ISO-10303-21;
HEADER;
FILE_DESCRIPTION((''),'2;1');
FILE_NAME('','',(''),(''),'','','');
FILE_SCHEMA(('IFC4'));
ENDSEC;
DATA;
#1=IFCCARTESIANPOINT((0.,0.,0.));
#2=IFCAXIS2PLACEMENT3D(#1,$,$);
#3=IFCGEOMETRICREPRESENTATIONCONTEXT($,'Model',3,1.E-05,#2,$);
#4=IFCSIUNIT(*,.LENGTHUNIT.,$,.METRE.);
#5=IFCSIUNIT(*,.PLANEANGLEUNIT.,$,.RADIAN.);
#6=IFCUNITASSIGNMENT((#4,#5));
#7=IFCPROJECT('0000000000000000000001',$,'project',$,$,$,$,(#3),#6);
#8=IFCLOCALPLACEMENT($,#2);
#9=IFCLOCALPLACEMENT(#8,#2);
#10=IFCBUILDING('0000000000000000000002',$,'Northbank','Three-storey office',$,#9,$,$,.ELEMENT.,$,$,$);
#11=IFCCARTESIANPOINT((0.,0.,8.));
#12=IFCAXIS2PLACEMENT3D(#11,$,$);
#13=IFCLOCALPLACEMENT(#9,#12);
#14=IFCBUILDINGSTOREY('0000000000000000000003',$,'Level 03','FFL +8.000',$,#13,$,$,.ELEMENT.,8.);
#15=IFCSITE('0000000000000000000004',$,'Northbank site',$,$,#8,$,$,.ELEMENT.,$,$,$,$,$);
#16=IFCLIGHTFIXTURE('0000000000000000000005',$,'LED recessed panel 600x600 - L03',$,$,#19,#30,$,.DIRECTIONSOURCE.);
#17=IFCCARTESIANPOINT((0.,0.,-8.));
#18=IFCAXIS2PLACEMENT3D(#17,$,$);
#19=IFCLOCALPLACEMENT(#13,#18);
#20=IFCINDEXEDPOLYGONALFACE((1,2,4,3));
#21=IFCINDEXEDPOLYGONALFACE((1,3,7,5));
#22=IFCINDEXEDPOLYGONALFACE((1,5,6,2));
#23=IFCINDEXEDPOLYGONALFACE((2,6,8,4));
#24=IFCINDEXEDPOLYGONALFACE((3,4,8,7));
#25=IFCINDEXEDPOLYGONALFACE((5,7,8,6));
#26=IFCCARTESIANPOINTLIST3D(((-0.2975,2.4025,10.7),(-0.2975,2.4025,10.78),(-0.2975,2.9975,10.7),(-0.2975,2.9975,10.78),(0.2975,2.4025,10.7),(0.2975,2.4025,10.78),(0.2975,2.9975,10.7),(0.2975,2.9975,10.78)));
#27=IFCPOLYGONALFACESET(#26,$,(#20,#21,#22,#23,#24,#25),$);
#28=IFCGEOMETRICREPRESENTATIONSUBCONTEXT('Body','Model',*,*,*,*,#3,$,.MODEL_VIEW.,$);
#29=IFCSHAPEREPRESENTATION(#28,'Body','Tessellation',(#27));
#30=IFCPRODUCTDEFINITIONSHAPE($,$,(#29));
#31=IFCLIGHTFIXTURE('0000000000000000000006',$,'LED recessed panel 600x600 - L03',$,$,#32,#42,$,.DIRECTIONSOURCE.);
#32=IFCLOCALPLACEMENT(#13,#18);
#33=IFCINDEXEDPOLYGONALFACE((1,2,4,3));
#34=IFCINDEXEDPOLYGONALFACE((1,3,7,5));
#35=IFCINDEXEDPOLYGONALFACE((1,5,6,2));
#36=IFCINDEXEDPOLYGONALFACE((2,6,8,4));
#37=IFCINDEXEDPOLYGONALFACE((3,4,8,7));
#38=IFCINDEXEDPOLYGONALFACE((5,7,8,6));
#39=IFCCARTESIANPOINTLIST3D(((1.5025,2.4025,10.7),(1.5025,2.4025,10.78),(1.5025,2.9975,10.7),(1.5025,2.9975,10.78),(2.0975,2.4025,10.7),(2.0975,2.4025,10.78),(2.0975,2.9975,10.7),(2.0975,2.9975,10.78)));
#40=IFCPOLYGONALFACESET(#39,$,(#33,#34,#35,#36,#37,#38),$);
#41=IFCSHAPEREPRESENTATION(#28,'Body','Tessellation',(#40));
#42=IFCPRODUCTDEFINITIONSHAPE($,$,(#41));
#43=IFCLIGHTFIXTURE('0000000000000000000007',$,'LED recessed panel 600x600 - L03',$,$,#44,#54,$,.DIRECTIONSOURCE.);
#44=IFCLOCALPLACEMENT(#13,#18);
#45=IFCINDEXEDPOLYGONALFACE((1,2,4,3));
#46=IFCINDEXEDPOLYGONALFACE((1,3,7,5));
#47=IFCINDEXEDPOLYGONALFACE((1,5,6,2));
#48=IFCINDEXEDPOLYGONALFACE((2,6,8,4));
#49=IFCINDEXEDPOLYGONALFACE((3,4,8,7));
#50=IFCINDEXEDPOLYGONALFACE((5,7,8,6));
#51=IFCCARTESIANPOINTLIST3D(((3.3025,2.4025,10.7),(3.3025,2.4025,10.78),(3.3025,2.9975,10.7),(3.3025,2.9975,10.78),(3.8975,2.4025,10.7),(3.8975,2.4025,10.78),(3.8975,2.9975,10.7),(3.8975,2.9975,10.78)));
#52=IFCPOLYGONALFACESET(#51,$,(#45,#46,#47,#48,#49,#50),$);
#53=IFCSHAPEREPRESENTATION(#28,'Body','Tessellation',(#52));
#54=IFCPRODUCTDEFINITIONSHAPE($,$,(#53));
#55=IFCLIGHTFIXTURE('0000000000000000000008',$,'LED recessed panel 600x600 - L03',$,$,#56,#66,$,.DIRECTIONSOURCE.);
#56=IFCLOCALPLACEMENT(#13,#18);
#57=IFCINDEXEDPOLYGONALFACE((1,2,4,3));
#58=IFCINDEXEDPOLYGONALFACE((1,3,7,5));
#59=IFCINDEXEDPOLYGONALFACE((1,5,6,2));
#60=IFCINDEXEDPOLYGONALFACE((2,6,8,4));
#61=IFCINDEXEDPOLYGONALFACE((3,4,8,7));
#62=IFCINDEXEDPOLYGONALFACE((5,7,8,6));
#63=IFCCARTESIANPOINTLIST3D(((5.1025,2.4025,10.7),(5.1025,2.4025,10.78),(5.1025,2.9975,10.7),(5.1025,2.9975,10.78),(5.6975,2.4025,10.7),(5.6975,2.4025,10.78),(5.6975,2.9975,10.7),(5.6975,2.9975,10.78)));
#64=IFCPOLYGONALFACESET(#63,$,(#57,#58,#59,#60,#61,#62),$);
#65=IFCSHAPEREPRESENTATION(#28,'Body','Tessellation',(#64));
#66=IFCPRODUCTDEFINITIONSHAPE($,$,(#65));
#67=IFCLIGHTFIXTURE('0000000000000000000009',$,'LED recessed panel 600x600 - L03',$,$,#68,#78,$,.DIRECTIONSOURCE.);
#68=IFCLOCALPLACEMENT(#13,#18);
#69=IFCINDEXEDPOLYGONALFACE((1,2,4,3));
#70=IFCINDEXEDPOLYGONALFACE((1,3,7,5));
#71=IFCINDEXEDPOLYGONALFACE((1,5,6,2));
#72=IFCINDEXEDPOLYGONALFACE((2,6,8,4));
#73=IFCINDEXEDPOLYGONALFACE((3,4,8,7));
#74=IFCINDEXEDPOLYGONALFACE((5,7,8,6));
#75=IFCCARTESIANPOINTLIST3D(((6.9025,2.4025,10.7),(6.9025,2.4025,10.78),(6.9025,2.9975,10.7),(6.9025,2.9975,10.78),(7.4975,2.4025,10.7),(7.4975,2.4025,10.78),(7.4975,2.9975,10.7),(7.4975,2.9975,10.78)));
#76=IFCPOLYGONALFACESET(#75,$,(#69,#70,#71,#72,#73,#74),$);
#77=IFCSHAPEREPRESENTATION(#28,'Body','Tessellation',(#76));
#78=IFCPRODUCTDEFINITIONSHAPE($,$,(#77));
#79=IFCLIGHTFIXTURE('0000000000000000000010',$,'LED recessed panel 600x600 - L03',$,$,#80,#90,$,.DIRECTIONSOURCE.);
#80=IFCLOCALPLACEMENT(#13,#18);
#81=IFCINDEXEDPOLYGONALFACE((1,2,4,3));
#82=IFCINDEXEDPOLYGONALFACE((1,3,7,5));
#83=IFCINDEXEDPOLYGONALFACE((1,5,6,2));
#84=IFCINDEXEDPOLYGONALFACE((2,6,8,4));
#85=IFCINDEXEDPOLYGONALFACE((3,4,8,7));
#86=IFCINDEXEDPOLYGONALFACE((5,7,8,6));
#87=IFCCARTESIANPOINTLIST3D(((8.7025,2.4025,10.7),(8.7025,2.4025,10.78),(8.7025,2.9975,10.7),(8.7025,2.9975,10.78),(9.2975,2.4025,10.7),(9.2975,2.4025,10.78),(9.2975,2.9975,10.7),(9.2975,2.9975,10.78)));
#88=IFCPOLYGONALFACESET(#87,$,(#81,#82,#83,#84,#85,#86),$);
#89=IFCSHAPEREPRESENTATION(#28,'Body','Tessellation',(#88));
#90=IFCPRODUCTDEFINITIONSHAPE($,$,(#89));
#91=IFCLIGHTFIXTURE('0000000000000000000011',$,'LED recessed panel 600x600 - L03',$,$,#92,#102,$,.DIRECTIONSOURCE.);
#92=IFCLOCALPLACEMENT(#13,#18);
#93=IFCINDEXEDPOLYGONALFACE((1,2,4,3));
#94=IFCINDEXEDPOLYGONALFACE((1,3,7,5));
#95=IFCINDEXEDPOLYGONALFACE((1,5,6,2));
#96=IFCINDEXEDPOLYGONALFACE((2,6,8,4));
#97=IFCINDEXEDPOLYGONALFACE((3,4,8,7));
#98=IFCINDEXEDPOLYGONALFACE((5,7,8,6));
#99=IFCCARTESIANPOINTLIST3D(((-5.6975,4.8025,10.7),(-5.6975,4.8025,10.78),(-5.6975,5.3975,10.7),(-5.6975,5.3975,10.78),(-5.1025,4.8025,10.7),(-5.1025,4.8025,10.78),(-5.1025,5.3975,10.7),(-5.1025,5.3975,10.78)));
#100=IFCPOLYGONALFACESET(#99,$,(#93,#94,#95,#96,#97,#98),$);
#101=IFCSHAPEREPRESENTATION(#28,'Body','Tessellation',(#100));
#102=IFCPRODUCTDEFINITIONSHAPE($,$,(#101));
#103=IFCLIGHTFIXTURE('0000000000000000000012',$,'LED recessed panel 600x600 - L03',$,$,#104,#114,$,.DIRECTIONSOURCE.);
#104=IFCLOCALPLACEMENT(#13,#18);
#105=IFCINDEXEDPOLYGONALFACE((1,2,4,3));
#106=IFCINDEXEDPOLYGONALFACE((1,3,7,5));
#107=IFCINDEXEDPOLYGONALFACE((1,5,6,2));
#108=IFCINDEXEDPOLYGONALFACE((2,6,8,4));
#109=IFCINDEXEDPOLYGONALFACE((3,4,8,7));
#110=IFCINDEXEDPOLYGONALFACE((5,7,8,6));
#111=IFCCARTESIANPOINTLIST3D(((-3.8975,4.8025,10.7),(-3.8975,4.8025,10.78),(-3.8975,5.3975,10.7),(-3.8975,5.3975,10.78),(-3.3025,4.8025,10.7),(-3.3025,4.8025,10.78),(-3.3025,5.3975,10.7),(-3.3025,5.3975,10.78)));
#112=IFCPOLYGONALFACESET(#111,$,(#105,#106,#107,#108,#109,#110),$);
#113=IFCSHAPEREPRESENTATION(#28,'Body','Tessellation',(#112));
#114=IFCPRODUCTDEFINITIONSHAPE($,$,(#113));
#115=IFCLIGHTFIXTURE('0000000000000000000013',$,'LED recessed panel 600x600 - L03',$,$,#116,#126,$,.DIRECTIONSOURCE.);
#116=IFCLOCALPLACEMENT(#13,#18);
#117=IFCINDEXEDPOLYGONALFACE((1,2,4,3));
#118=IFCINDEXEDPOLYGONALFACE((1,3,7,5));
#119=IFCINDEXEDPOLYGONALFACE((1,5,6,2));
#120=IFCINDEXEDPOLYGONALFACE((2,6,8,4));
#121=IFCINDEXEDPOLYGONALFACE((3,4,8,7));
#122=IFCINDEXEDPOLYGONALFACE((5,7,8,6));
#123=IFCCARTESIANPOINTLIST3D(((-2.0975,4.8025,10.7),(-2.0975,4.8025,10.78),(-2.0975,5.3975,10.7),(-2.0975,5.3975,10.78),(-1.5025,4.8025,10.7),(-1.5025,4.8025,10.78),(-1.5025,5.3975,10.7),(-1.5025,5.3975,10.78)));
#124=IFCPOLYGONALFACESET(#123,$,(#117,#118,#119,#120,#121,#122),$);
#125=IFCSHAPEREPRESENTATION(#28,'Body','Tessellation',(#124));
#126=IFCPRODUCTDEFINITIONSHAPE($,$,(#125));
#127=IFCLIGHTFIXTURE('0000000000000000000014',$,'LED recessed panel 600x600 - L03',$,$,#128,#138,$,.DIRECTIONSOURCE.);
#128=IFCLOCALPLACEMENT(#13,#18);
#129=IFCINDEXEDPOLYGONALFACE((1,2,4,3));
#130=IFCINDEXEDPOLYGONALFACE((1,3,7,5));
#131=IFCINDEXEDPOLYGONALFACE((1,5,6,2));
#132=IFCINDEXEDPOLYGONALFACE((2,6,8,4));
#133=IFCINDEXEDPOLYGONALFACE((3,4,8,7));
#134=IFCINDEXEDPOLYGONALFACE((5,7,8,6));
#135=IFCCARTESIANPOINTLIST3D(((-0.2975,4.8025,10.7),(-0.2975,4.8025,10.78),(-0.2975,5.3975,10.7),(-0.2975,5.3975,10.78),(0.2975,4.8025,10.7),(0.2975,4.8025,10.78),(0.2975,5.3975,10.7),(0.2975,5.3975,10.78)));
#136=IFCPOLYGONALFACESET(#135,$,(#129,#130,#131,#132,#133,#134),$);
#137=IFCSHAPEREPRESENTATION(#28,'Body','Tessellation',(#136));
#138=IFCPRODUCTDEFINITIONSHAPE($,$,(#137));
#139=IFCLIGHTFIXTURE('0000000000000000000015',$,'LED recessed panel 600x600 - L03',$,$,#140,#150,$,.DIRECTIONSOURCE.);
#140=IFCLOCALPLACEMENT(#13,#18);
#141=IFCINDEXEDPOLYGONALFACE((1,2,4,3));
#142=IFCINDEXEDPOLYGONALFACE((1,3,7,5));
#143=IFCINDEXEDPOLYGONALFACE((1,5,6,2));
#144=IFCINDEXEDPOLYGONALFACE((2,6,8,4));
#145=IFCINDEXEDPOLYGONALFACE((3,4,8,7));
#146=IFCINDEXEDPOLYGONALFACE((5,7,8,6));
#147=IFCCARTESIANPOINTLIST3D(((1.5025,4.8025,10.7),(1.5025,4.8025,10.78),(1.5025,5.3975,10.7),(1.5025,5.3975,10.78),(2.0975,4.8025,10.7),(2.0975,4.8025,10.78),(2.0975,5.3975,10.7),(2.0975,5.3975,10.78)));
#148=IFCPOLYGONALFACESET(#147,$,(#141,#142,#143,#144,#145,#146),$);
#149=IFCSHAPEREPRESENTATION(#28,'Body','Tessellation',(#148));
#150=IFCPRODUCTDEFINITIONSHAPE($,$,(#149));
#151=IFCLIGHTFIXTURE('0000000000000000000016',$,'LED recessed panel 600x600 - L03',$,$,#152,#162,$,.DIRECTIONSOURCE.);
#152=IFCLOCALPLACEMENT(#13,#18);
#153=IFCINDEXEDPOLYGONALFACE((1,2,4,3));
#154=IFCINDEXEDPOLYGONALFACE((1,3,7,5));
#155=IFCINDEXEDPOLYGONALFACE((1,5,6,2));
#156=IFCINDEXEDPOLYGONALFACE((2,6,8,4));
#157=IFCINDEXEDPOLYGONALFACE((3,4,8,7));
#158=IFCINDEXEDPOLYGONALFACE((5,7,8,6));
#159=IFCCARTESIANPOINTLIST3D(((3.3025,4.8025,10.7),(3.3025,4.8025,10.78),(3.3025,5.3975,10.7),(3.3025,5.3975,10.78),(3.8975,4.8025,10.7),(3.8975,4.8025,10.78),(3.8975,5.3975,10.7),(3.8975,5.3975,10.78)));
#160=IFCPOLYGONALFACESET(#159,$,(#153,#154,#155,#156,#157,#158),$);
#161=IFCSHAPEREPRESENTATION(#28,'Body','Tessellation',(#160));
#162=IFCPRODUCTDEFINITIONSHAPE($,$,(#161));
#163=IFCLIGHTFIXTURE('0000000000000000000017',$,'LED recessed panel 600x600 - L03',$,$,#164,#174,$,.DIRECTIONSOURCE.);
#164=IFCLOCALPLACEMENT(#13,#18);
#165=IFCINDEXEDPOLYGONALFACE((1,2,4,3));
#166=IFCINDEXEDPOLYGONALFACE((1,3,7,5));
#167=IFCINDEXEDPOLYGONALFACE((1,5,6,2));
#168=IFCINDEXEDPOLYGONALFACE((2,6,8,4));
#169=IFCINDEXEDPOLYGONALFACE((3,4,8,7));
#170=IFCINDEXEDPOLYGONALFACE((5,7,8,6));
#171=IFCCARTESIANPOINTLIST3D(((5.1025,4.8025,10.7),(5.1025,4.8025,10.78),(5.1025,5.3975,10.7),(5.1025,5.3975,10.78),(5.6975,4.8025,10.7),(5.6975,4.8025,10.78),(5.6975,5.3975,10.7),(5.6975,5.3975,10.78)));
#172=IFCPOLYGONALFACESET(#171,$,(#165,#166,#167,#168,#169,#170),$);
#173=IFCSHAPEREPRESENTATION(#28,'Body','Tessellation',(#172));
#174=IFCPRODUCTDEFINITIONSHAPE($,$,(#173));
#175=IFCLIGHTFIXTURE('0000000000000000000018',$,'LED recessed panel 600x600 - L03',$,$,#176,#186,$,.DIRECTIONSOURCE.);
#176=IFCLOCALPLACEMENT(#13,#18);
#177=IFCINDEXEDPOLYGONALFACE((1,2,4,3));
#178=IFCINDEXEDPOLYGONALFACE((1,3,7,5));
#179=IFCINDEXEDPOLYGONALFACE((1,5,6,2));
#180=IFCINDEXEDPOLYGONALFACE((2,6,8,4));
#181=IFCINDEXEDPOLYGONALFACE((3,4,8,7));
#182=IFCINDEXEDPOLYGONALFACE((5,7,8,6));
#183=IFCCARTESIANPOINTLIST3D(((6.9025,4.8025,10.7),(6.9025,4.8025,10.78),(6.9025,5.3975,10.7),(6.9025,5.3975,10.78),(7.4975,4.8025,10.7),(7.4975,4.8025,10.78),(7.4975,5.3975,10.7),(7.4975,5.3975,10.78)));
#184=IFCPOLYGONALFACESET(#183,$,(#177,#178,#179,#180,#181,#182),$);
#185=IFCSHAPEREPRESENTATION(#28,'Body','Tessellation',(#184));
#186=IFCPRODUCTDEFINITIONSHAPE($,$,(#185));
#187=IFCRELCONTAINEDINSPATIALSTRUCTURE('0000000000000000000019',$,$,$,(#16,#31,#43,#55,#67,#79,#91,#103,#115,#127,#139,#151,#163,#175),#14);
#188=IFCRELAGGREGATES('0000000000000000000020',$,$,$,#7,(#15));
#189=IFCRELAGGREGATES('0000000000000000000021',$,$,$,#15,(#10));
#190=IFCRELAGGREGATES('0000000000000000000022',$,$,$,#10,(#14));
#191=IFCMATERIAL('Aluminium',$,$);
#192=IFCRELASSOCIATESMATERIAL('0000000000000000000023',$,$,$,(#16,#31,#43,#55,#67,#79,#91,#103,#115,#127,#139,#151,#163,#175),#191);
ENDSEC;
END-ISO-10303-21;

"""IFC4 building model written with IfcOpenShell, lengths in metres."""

from ifc_helpers import new_model, si_unit, frame, origin, place, context, subcontext, project, spatial, rectangle, extrude, material, element, save


model = new_model("IFC4")

# Units and contexts
model_context = context("Model", 3, precision=1e-05, world=origin())
body_context = subcontext(model_context, "Body", "Model", "MODEL_VIEW")
ifc_project = project(units=[si_unit("LENGTHUNIT", "METRE"), si_unit("PLANEANGLEUNIT", "RADIAN")], contexts=[model_context])

# Site, building, storey
site_placement = place(None, origin())
site = spatial("IfcSite", under=ifc_project, at=site_placement, Name="Northbank site", CompositionType="ELEMENT")
building_placement = place(site_placement, origin())
building = spatial("IfcBuilding", under=site, at=building_placement, Name="Northbank", Description="Three-storey office", CompositionType="ELEMENT")
storey_placement = place(building_placement, frame((0.0, 0.0, 8.0)))
storey = spatial("IfcBuildingStorey", under=building, at=storey_placement, Name="Level 03", Description="FFL +8.000", CompositionType="ELEMENT", Elevation=8.0)

# Light fixtures
ifc_material_1 = material(Name="Aluminium")
light_fixture_1_placement = place(storey_placement, frame((0.0, 0.0, -8.0)))
element("IfcLightFixture", 1, at=light_fixture_1_placement, inside=storey, material=ifc_material_1, Name="LED recessed panel 600x600 - L03", PredefinedType="DIRECTIONSOURCE", context=body_context, shape_type="SweptSolid", body=[
    extrude(rectangle(XDim=0.595, YDim=0.595), frame((0.0, 2.7, 10.7)), (0.0, 0.0, 1.0), 0.08),
])
light_fixture_2_placement = place(storey_placement, frame((0.0, 0.0, -8.0)))
element("IfcLightFixture", 2, at=light_fixture_2_placement, inside=storey, material=ifc_material_1, Name="LED recessed panel 600x600 - L03", PredefinedType="DIRECTIONSOURCE", context=body_context, shape_type="SweptSolid", body=[
    extrude(rectangle(XDim=0.595, YDim=0.595), frame((1.8, 2.7, 10.7)), (0.0, 0.0, 1.0), 0.08),
])
light_fixture_3_placement = place(storey_placement, frame((0.0, 0.0, -8.0)))
element("IfcLightFixture", 3, at=light_fixture_3_placement, inside=storey, material=ifc_material_1, Name="LED recessed panel 600x600 - L03", PredefinedType="DIRECTIONSOURCE", context=body_context, shape_type="SweptSolid", body=[
    extrude(rectangle(XDim=0.595, YDim=0.595), frame((3.6, 2.7, 10.7)), (0.0, 0.0, 1.0), 0.08),
])
light_fixture_4_placement = place(storey_placement, frame((0.0, 0.0, -8.0)))
element("IfcLightFixture", 4, at=light_fixture_4_placement, inside=storey, material=ifc_material_1, Name="LED recessed panel 600x600 - L03", PredefinedType="DIRECTIONSOURCE", context=body_context, shape_type="SweptSolid", body=[
    extrude(rectangle(XDim=0.595, YDim=0.595), frame((5.4, 2.7, 10.7)), (0.0, 0.0, 1.0), 0.08),
])
light_fixture_5_placement = place(storey_placement, frame((0.0, 0.0, -8.0)))
element("IfcLightFixture", 5, at=light_fixture_5_placement, inside=storey, material=ifc_material_1, Name="LED recessed panel 600x600 - L03", PredefinedType="DIRECTIONSOURCE", context=body_context, shape_type="SweptSolid", body=[
    extrude(rectangle(XDim=0.595, YDim=0.595), frame((7.2, 2.7, 10.7)), (0.0, 0.0, 1.0), 0.08),
])
light_fixture_6_placement = place(storey_placement, frame((0.0, 0.0, -8.0)))
element("IfcLightFixture", 6, at=light_fixture_6_placement, inside=storey, material=ifc_material_1, Name="LED recessed panel 600x600 - L03", PredefinedType="DIRECTIONSOURCE", context=body_context, shape_type="SweptSolid", body=[
    extrude(rectangle(XDim=0.595, YDim=0.595), frame((9.0, 2.7, 10.7)), (0.0, 0.0, 1.0), 0.08),
])
light_fixture_7_placement = place(storey_placement, frame((0.0, 0.0, -8.0)))
element("IfcLightFixture", 7, at=light_fixture_7_placement, inside=storey, material=ifc_material_1, Name="LED recessed panel 600x600 - L03", PredefinedType="DIRECTIONSOURCE", context=body_context, shape_type="SweptSolid", body=[
    extrude(rectangle(XDim=0.595, YDim=0.595), frame((-5.4, 5.1, 10.7)), (0.0, 0.0, 1.0), 0.08),
])
light_fixture_8_placement = place(storey_placement, frame((0.0, 0.0, -8.0)))
element("IfcLightFixture", 8, at=light_fixture_8_placement, inside=storey, material=ifc_material_1, Name="LED recessed panel 600x600 - L03", PredefinedType="DIRECTIONSOURCE", context=body_context, shape_type="SweptSolid", body=[
    extrude(rectangle(XDim=0.595, YDim=0.595), frame((-3.6, 5.1, 10.7)), (0.0, 0.0, 1.0), 0.08),
])
light_fixture_9_placement = place(storey_placement, frame((0.0, 0.0, -8.0)))
element("IfcLightFixture", 9, at=light_fixture_9_placement, inside=storey, material=ifc_material_1, Name="LED recessed panel 600x600 - L03", PredefinedType="DIRECTIONSOURCE", context=body_context, shape_type="SweptSolid", body=[
    extrude(rectangle(XDim=0.595, YDim=0.595), frame((-1.8, 5.1, 10.7)), (0.0, 0.0, 1.0), 0.08),
])
light_fixture_10_placement = place(storey_placement, frame((0.0, 0.0, -8.0)))
element("IfcLightFixture", 10, at=light_fixture_10_placement, inside=storey, material=ifc_material_1, Name="LED recessed panel 600x600 - L03", PredefinedType="DIRECTIONSOURCE", context=body_context, shape_type="SweptSolid", body=[
    extrude(rectangle(XDim=0.595, YDim=0.595), frame((0.0, 5.1, 10.7)), (0.0, 0.0, 1.0), 0.08),
])
light_fixture_11_placement = place(storey_placement, frame((0.0, 0.0, -8.0)))
element("IfcLightFixture", 11, at=light_fixture_11_placement, inside=storey, material=ifc_material_1, Name="LED recessed panel 600x600 - L03", PredefinedType="DIRECTIONSOURCE", context=body_context, shape_type="SweptSolid", body=[
    extrude(rectangle(XDim=0.595, YDim=0.595), frame((1.8, 5.1, 10.7)), (0.0, 0.0, 1.0), 0.08),
])
light_fixture_12_placement = place(storey_placement, frame((0.0, 0.0, -8.0)))
element("IfcLightFixture", 12, at=light_fixture_12_placement, inside=storey, material=ifc_material_1, Name="LED recessed panel 600x600 - L03", PredefinedType="DIRECTIONSOURCE", context=body_context, shape_type="SweptSolid", body=[
    extrude(rectangle(XDim=0.595, YDim=0.595), frame((3.6, 5.1, 10.7)), (0.0, 0.0, 1.0), 0.08),
])
light_fixture_13_placement = place(storey_placement, frame((0.0, 0.0, -8.0)))
element("IfcLightFixture", 13, at=light_fixture_13_placement, inside=storey, material=ifc_material_1, Name="LED recessed panel 600x600 - L03", PredefinedType="DIRECTIONSOURCE", context=body_context, shape_type="SweptSolid", body=[
    extrude(rectangle(XDim=0.595, YDim=0.595), frame((5.4, 5.1, 10.7)), (0.0, 0.0, 1.0), 0.08),
])
light_fixture_14_placement = place(storey_placement, frame((0.0, 0.0, -8.0)))
element("IfcLightFixture", 14, at=light_fixture_14_placement, inside=storey, material=ifc_material_1, Name="LED recessed panel 600x600 - L03", PredefinedType="DIRECTIONSOURCE", context=body_context, shape_type="SweptSolid", body=[
    extrude(rectangle(XDim=0.595, YDim=0.595), frame((7.2, 5.1, 10.7)), (0.0, 0.0, 1.0), 0.08),
])

save(model, "model.ifc")
